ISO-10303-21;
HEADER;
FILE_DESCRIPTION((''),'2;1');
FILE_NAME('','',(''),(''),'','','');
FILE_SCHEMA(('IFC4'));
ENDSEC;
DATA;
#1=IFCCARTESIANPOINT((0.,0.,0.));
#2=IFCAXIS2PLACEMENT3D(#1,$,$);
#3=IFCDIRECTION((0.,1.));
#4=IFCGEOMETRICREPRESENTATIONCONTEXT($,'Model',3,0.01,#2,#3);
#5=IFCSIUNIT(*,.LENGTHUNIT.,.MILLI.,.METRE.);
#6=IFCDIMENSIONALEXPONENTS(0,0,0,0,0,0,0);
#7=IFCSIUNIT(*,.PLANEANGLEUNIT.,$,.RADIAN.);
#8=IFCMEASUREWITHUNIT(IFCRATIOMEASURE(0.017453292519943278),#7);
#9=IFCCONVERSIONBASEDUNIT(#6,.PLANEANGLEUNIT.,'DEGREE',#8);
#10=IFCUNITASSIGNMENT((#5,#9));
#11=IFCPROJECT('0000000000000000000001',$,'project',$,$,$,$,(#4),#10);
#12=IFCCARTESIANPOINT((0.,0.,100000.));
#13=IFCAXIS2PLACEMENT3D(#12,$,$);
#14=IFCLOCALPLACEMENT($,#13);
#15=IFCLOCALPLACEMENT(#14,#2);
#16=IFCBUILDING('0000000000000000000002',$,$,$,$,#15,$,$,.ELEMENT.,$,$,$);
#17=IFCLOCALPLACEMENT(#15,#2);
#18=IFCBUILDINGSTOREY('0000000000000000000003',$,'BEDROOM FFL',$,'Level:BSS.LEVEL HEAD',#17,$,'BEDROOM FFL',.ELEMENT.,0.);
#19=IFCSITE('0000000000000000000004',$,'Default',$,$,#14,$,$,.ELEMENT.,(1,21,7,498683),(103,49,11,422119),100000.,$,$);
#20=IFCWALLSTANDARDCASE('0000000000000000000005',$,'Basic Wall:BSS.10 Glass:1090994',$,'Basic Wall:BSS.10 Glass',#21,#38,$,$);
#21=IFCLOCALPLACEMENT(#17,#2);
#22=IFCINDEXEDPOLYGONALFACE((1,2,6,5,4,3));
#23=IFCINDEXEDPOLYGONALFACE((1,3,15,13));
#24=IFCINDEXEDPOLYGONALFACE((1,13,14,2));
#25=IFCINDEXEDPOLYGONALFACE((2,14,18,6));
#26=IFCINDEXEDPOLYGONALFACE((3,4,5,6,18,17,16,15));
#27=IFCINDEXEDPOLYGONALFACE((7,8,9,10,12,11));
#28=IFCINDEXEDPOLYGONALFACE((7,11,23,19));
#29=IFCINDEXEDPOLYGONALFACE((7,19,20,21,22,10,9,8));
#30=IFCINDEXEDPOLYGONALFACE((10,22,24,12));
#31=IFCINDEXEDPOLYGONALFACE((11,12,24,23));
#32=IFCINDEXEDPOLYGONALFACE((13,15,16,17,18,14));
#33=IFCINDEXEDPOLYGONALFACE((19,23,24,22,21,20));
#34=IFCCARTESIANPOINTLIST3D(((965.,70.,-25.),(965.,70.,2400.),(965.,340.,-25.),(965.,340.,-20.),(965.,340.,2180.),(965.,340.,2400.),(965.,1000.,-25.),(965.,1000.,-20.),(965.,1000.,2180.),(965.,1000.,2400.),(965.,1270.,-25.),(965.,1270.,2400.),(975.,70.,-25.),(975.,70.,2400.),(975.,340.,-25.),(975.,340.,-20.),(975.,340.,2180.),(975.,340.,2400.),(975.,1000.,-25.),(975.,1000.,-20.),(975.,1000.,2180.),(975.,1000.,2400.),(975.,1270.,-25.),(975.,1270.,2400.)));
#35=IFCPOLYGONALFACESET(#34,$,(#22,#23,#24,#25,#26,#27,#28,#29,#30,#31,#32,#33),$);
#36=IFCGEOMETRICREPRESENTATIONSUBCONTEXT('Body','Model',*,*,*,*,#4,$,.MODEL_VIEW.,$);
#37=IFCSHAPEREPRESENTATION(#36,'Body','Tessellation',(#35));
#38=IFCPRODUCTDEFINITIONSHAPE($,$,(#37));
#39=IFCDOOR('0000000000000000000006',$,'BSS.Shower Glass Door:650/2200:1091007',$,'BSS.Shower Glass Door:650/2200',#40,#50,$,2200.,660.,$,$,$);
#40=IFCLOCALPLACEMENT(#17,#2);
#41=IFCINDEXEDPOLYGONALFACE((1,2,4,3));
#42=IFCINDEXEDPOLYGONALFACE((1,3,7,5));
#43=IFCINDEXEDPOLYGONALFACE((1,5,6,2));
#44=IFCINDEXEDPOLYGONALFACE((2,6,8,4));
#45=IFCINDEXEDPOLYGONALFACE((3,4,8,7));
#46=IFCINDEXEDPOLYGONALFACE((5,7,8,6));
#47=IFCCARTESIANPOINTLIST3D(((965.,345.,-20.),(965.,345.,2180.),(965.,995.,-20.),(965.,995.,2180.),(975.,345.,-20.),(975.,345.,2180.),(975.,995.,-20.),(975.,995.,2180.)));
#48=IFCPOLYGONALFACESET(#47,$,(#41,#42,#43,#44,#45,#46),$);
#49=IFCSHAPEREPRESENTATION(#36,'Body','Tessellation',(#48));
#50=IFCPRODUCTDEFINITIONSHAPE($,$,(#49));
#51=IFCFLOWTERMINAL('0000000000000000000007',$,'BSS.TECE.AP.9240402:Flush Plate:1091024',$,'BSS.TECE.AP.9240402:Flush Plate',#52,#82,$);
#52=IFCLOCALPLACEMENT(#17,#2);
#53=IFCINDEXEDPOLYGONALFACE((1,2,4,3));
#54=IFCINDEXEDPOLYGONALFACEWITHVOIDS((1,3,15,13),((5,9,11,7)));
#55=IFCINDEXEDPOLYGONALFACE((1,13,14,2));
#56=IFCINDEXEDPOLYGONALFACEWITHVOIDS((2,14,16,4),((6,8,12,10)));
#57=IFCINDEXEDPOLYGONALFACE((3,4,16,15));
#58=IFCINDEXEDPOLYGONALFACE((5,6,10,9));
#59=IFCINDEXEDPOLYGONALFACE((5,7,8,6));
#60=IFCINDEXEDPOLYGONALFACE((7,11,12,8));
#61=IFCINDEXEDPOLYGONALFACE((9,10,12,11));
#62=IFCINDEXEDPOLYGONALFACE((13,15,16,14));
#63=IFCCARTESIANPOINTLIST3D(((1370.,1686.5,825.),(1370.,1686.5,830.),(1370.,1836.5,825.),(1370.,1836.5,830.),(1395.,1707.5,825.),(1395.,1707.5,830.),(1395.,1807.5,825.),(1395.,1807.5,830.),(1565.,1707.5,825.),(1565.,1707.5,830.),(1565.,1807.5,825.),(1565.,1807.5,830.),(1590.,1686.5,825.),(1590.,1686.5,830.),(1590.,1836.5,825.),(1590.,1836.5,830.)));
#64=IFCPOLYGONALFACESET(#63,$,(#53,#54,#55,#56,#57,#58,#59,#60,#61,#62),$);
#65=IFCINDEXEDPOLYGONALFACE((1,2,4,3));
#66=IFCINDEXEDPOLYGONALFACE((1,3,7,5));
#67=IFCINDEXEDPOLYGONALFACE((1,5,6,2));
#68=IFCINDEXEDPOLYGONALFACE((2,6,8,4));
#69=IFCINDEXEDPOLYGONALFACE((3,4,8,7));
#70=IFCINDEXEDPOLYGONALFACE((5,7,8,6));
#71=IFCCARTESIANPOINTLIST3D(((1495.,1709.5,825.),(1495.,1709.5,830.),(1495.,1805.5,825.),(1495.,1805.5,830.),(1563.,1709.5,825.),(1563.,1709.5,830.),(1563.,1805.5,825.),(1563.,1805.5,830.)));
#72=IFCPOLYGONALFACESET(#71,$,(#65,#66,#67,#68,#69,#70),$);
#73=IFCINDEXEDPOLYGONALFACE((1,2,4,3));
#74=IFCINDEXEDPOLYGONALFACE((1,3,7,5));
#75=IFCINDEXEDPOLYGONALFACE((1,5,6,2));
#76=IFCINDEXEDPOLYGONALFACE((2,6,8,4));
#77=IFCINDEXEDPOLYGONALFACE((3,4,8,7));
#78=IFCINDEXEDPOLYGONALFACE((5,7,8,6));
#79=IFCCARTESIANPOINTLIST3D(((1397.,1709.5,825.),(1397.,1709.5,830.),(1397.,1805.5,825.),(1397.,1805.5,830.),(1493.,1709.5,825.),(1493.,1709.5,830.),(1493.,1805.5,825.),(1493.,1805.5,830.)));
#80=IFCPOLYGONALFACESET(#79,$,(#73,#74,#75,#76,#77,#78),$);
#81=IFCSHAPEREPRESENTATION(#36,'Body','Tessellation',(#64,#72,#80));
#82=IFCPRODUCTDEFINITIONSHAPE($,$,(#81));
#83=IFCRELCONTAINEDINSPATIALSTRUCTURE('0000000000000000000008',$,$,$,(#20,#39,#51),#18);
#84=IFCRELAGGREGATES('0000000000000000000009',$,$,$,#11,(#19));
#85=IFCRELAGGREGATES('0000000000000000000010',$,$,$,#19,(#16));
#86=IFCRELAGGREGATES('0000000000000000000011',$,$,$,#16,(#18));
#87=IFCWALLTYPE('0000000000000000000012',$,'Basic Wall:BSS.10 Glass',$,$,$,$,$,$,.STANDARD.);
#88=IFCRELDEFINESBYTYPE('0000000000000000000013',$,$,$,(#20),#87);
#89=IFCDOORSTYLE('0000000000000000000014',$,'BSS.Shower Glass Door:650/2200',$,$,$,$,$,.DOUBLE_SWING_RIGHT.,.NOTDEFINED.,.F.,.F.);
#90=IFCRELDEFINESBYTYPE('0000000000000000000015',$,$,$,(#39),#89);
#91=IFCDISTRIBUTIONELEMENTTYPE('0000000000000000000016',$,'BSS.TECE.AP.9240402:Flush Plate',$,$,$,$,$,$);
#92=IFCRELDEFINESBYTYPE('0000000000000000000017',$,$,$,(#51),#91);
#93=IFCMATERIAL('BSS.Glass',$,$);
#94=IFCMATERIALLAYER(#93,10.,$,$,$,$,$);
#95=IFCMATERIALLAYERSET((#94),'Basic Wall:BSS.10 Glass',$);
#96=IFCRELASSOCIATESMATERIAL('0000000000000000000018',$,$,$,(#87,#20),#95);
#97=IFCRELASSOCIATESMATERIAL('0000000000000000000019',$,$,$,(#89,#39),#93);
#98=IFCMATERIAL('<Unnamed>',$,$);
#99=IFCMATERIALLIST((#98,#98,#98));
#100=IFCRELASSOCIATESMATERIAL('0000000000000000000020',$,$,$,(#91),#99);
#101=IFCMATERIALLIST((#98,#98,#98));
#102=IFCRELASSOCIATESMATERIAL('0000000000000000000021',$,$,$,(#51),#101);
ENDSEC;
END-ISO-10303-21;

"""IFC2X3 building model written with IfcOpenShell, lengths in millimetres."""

from ifc_helpers import new_model, entity, si_unit, converted_unit, direction, frame, frame_2d, origin, origin_2d_with_axis, place, context, subcontext, project, spatial, polyline, rectangle, outline, extrude, source, transform, mapped, material, material_list, layer, layer_set, layer_usage, type_object, type_shapes, element, fill, save


model = new_model("IFC2X3")

# Units and contexts
model_context = context("Model", 3, precision=0.01, world=origin(), true_north=direction((0.0, 1.0)))
body_context = subcontext(model_context, "Body", "Model", "MODEL_VIEW")
ifc_project = project(units=[si_unit("LENGTHUNIT", "METRE", prefix="MILLI"), converted_unit("PLANEANGLEUNIT", "DEGREE", entity("IfcRatioMeasure", 0.017453292519943278), si_unit("PLANEANGLEUNIT", "RADIAN"), dimensions=[0, 0, 0, 0, 0, 0, 0])], contexts=[model_context])

# Site, building, storey
site_placement = place(None, frame((0.0, 0.0, 100000.0)))
site = spatial("IfcSite", under=ifc_project, at=site_placement, Name="Default", CompositionType="ELEMENT", RefLatitude=(1, 21, 7, 498683), RefLongitude=(103, 49, 11, 422119), RefElevation=100000.0)
building_placement = place(site_placement, origin())
building = spatial("IfcBuilding", under=site, at=building_placement, CompositionType="ELEMENT")
storey_placement = place(building_placement, origin())
storey = spatial("IfcBuildingStorey", under=building, at=storey_placement, Name="BEDROOM FFL", ObjectType="Level:BSS.LEVEL HEAD", LongName="BEDROOM FFL", CompositionType="ELEMENT", Elevation=0.0)

# Wall, openings, door
ifc_material_1 = material(Name="BSS.Glass")
ifc_layer_1 = layer(ifc_material_1, 10.0)
ifc_layer_set_1 = layer_set([ifc_layer_1], Name="Basic Wall:BSS.10 Glass")
ifc_layer_usage_1 = layer_usage(ifc_layer_set_1, "AXIS2", "POSITIVE", -5.0)
wall_type_1 = type_object("IfcWallType", Name="Basic Wall:BSS.10 Glass", PredefinedType="STANDARD", material=ifc_layer_set_1)
wall_1_placement = place(storey_placement, frame((970.0, 70.0, -25.0), z_axis=(0.0, 0.0, 1.0), x_axis=(0.0, 1.0, 0.0)))
wall_1 = element("IfcWallStandardCase", 1, at=wall_1_placement, inside=storey, type_object=wall_type_1, material=ifc_layer_usage_1, Name="Basic Wall:BSS.10 Glass:1090994", ObjectType="Basic Wall:BSS.10 Glass", context=body_context, shape_type="SweptSolid", body=[
    extrude(rectangle(XDim=1200.0, YDim=10.0, at=frame_2d((600.0, 0.0), x_axis=(-1.0, 0.0))), origin(), (0.0, 0.0, 1.0), 2425.0),
])
opening_1_placement = place(wall_1_placement, origin())
element("IfcOpeningElement", 2, at=opening_1_placement, cuts=wall_1, ObjectType="Opening", context=body_context, shape_type="SweptSolid", body=[
    extrude(rectangle(XDim=2450.0, YDim=660.0, at=origin_2d_with_axis()), frame((600.0, -5.0, 1225.0), z_axis=(0.0, 1.0, 0.0), x_axis=(0.0, 0.0, -1.0)), (0.0, 0.0, 1.0), 10.0),
])
opening_2_placement = place(wall_1_placement, frame((930.0, 5.0, 5.0)))
opening_2 = element("IfcOpeningElement", 3, at=opening_2_placement, cuts=wall_1, ObjectType="Opening", context=body_context, shape_type="SweptSolid", body=[
    extrude(rectangle(XDim=660.0, YDim=2200.0, at=frame_2d((1100.0, 330.0), x_axis=(0.0, 1.0))), frame((0.0, 0.0, 0.0), z_axis=(0.0, -1.0, 0.0), x_axis=(0.0, 0.0, 1.0)), (0.0, 0.0, 1.0), 10.0),
])
door_style = type_object("IfcDoorStyle", Name="BSS.Shower Glass Door:650/2200", ConstructionType="NOTDEFINED", OperationType="DOUBLE_SWING_RIGHT", ParameterTakesPrecedence=False, Sizeable=False, material=ifc_material_1)
shared_shape_1 = source(origin(), body_context, "Body", "SweptSolid", [
    extrude(rectangle(XDim=650.0, YDim=10.0, at=origin_2d_with_axis()), frame((330.0, 5.0, 0.0), z_axis=(0.0, 0.0, 1.0), x_axis=(-1.0, 0.0, 0.0)), (0.0, 0.0, 1.0), 2200.0),
])
type_shapes(door_style, [shared_shape_1])
door_placement = place(opening_2_placement, frame((0.0, 0.0, 0.0), z_axis=(0.0, 0.0, 1.0), x_axis=(-1.0, 0.0, 0.0)))
door = element("IfcDoor", 4, at=door_placement, inside=storey, type_object=door_style, material=ifc_material_1, Name="BSS.Shower Glass Door:650/2200:1091007", ObjectType="BSS.Shower Glass Door:650/2200", OverallHeight=2200.0, OverallWidth=660.0, context=body_context, shape_type="MappedRepresentation", body=[
    mapped(shared_shape_1, transform((0.0, 0.0, 0.0), scale=1.0)),
])
fill(opening_2, door)

# Flow terminal
ifc_material_2 = material(Name="<Unnamed>")
ifc_material_list_1 = material_list([ifc_material_2, ifc_material_2, ifc_material_2])
ifc_material_list_2 = material_list([ifc_material_2, ifc_material_2, ifc_material_2])
distribution_element_type = type_object("IfcDistributionElementType", Name="BSS.TECE.AP.9240402:Flush Plate", material=ifc_material_list_2)
shared_shape_2 = source(origin(), body_context, "Body", "SweptSolid", [
    extrude(outline(polyline([(-110.0, -75.0), (110.0, -75.0), (110.0, 75.0), (-110.0, 75.0), (-110.0, -75.0)]), holes=[polyline([(-85.0, -46.0), (-85.0, 54.0), (85.0, 54.0), (85.0, -46.0), (-85.0, -46.0)])]), frame((0.0, 0.0, 0.0), z_axis=(0.0, 0.0, 1.0), x_axis=(-1.0, 0.0, 0.0)), (0.0, 0.0, 1.0), 5.0),
    extrude(rectangle(XDim=68.0, YDim=96.0, at=frame_2d((0.0, 0.0), x_axis=(1.0, 0.0))), frame((49.0, -4.0, 0.0)), (0.0, 0.0, 1.0), 5.0),
    extrude(rectangle(XDim=96.0, YDim=96.0, at=frame_2d((0.0, 0.0), x_axis=(1.0, 0.0))), frame((-35.0, -4.0, 0.0)), (0.0, 0.0, 1.0), 5.0),
])
type_shapes(distribution_element_type, [shared_shape_2])
flow_terminal_placement = place(storey_placement, frame((1480.0, 1761.5, 825.0)))
element("IfcFlowTerminal", 5, at=flow_terminal_placement, inside=storey, type_object=distribution_element_type, material=ifc_material_list_1, Name="BSS.TECE.AP.9240402:Flush Plate:1091024", ObjectType="BSS.TECE.AP.9240402:Flush Plate", context=body_context, shape_type="MappedRepresentation", body=[
    mapped(shared_shape_2, transform((0.0, 0.0, 0.0), scale=1.0)),
])

save(model, "model.ifc")
